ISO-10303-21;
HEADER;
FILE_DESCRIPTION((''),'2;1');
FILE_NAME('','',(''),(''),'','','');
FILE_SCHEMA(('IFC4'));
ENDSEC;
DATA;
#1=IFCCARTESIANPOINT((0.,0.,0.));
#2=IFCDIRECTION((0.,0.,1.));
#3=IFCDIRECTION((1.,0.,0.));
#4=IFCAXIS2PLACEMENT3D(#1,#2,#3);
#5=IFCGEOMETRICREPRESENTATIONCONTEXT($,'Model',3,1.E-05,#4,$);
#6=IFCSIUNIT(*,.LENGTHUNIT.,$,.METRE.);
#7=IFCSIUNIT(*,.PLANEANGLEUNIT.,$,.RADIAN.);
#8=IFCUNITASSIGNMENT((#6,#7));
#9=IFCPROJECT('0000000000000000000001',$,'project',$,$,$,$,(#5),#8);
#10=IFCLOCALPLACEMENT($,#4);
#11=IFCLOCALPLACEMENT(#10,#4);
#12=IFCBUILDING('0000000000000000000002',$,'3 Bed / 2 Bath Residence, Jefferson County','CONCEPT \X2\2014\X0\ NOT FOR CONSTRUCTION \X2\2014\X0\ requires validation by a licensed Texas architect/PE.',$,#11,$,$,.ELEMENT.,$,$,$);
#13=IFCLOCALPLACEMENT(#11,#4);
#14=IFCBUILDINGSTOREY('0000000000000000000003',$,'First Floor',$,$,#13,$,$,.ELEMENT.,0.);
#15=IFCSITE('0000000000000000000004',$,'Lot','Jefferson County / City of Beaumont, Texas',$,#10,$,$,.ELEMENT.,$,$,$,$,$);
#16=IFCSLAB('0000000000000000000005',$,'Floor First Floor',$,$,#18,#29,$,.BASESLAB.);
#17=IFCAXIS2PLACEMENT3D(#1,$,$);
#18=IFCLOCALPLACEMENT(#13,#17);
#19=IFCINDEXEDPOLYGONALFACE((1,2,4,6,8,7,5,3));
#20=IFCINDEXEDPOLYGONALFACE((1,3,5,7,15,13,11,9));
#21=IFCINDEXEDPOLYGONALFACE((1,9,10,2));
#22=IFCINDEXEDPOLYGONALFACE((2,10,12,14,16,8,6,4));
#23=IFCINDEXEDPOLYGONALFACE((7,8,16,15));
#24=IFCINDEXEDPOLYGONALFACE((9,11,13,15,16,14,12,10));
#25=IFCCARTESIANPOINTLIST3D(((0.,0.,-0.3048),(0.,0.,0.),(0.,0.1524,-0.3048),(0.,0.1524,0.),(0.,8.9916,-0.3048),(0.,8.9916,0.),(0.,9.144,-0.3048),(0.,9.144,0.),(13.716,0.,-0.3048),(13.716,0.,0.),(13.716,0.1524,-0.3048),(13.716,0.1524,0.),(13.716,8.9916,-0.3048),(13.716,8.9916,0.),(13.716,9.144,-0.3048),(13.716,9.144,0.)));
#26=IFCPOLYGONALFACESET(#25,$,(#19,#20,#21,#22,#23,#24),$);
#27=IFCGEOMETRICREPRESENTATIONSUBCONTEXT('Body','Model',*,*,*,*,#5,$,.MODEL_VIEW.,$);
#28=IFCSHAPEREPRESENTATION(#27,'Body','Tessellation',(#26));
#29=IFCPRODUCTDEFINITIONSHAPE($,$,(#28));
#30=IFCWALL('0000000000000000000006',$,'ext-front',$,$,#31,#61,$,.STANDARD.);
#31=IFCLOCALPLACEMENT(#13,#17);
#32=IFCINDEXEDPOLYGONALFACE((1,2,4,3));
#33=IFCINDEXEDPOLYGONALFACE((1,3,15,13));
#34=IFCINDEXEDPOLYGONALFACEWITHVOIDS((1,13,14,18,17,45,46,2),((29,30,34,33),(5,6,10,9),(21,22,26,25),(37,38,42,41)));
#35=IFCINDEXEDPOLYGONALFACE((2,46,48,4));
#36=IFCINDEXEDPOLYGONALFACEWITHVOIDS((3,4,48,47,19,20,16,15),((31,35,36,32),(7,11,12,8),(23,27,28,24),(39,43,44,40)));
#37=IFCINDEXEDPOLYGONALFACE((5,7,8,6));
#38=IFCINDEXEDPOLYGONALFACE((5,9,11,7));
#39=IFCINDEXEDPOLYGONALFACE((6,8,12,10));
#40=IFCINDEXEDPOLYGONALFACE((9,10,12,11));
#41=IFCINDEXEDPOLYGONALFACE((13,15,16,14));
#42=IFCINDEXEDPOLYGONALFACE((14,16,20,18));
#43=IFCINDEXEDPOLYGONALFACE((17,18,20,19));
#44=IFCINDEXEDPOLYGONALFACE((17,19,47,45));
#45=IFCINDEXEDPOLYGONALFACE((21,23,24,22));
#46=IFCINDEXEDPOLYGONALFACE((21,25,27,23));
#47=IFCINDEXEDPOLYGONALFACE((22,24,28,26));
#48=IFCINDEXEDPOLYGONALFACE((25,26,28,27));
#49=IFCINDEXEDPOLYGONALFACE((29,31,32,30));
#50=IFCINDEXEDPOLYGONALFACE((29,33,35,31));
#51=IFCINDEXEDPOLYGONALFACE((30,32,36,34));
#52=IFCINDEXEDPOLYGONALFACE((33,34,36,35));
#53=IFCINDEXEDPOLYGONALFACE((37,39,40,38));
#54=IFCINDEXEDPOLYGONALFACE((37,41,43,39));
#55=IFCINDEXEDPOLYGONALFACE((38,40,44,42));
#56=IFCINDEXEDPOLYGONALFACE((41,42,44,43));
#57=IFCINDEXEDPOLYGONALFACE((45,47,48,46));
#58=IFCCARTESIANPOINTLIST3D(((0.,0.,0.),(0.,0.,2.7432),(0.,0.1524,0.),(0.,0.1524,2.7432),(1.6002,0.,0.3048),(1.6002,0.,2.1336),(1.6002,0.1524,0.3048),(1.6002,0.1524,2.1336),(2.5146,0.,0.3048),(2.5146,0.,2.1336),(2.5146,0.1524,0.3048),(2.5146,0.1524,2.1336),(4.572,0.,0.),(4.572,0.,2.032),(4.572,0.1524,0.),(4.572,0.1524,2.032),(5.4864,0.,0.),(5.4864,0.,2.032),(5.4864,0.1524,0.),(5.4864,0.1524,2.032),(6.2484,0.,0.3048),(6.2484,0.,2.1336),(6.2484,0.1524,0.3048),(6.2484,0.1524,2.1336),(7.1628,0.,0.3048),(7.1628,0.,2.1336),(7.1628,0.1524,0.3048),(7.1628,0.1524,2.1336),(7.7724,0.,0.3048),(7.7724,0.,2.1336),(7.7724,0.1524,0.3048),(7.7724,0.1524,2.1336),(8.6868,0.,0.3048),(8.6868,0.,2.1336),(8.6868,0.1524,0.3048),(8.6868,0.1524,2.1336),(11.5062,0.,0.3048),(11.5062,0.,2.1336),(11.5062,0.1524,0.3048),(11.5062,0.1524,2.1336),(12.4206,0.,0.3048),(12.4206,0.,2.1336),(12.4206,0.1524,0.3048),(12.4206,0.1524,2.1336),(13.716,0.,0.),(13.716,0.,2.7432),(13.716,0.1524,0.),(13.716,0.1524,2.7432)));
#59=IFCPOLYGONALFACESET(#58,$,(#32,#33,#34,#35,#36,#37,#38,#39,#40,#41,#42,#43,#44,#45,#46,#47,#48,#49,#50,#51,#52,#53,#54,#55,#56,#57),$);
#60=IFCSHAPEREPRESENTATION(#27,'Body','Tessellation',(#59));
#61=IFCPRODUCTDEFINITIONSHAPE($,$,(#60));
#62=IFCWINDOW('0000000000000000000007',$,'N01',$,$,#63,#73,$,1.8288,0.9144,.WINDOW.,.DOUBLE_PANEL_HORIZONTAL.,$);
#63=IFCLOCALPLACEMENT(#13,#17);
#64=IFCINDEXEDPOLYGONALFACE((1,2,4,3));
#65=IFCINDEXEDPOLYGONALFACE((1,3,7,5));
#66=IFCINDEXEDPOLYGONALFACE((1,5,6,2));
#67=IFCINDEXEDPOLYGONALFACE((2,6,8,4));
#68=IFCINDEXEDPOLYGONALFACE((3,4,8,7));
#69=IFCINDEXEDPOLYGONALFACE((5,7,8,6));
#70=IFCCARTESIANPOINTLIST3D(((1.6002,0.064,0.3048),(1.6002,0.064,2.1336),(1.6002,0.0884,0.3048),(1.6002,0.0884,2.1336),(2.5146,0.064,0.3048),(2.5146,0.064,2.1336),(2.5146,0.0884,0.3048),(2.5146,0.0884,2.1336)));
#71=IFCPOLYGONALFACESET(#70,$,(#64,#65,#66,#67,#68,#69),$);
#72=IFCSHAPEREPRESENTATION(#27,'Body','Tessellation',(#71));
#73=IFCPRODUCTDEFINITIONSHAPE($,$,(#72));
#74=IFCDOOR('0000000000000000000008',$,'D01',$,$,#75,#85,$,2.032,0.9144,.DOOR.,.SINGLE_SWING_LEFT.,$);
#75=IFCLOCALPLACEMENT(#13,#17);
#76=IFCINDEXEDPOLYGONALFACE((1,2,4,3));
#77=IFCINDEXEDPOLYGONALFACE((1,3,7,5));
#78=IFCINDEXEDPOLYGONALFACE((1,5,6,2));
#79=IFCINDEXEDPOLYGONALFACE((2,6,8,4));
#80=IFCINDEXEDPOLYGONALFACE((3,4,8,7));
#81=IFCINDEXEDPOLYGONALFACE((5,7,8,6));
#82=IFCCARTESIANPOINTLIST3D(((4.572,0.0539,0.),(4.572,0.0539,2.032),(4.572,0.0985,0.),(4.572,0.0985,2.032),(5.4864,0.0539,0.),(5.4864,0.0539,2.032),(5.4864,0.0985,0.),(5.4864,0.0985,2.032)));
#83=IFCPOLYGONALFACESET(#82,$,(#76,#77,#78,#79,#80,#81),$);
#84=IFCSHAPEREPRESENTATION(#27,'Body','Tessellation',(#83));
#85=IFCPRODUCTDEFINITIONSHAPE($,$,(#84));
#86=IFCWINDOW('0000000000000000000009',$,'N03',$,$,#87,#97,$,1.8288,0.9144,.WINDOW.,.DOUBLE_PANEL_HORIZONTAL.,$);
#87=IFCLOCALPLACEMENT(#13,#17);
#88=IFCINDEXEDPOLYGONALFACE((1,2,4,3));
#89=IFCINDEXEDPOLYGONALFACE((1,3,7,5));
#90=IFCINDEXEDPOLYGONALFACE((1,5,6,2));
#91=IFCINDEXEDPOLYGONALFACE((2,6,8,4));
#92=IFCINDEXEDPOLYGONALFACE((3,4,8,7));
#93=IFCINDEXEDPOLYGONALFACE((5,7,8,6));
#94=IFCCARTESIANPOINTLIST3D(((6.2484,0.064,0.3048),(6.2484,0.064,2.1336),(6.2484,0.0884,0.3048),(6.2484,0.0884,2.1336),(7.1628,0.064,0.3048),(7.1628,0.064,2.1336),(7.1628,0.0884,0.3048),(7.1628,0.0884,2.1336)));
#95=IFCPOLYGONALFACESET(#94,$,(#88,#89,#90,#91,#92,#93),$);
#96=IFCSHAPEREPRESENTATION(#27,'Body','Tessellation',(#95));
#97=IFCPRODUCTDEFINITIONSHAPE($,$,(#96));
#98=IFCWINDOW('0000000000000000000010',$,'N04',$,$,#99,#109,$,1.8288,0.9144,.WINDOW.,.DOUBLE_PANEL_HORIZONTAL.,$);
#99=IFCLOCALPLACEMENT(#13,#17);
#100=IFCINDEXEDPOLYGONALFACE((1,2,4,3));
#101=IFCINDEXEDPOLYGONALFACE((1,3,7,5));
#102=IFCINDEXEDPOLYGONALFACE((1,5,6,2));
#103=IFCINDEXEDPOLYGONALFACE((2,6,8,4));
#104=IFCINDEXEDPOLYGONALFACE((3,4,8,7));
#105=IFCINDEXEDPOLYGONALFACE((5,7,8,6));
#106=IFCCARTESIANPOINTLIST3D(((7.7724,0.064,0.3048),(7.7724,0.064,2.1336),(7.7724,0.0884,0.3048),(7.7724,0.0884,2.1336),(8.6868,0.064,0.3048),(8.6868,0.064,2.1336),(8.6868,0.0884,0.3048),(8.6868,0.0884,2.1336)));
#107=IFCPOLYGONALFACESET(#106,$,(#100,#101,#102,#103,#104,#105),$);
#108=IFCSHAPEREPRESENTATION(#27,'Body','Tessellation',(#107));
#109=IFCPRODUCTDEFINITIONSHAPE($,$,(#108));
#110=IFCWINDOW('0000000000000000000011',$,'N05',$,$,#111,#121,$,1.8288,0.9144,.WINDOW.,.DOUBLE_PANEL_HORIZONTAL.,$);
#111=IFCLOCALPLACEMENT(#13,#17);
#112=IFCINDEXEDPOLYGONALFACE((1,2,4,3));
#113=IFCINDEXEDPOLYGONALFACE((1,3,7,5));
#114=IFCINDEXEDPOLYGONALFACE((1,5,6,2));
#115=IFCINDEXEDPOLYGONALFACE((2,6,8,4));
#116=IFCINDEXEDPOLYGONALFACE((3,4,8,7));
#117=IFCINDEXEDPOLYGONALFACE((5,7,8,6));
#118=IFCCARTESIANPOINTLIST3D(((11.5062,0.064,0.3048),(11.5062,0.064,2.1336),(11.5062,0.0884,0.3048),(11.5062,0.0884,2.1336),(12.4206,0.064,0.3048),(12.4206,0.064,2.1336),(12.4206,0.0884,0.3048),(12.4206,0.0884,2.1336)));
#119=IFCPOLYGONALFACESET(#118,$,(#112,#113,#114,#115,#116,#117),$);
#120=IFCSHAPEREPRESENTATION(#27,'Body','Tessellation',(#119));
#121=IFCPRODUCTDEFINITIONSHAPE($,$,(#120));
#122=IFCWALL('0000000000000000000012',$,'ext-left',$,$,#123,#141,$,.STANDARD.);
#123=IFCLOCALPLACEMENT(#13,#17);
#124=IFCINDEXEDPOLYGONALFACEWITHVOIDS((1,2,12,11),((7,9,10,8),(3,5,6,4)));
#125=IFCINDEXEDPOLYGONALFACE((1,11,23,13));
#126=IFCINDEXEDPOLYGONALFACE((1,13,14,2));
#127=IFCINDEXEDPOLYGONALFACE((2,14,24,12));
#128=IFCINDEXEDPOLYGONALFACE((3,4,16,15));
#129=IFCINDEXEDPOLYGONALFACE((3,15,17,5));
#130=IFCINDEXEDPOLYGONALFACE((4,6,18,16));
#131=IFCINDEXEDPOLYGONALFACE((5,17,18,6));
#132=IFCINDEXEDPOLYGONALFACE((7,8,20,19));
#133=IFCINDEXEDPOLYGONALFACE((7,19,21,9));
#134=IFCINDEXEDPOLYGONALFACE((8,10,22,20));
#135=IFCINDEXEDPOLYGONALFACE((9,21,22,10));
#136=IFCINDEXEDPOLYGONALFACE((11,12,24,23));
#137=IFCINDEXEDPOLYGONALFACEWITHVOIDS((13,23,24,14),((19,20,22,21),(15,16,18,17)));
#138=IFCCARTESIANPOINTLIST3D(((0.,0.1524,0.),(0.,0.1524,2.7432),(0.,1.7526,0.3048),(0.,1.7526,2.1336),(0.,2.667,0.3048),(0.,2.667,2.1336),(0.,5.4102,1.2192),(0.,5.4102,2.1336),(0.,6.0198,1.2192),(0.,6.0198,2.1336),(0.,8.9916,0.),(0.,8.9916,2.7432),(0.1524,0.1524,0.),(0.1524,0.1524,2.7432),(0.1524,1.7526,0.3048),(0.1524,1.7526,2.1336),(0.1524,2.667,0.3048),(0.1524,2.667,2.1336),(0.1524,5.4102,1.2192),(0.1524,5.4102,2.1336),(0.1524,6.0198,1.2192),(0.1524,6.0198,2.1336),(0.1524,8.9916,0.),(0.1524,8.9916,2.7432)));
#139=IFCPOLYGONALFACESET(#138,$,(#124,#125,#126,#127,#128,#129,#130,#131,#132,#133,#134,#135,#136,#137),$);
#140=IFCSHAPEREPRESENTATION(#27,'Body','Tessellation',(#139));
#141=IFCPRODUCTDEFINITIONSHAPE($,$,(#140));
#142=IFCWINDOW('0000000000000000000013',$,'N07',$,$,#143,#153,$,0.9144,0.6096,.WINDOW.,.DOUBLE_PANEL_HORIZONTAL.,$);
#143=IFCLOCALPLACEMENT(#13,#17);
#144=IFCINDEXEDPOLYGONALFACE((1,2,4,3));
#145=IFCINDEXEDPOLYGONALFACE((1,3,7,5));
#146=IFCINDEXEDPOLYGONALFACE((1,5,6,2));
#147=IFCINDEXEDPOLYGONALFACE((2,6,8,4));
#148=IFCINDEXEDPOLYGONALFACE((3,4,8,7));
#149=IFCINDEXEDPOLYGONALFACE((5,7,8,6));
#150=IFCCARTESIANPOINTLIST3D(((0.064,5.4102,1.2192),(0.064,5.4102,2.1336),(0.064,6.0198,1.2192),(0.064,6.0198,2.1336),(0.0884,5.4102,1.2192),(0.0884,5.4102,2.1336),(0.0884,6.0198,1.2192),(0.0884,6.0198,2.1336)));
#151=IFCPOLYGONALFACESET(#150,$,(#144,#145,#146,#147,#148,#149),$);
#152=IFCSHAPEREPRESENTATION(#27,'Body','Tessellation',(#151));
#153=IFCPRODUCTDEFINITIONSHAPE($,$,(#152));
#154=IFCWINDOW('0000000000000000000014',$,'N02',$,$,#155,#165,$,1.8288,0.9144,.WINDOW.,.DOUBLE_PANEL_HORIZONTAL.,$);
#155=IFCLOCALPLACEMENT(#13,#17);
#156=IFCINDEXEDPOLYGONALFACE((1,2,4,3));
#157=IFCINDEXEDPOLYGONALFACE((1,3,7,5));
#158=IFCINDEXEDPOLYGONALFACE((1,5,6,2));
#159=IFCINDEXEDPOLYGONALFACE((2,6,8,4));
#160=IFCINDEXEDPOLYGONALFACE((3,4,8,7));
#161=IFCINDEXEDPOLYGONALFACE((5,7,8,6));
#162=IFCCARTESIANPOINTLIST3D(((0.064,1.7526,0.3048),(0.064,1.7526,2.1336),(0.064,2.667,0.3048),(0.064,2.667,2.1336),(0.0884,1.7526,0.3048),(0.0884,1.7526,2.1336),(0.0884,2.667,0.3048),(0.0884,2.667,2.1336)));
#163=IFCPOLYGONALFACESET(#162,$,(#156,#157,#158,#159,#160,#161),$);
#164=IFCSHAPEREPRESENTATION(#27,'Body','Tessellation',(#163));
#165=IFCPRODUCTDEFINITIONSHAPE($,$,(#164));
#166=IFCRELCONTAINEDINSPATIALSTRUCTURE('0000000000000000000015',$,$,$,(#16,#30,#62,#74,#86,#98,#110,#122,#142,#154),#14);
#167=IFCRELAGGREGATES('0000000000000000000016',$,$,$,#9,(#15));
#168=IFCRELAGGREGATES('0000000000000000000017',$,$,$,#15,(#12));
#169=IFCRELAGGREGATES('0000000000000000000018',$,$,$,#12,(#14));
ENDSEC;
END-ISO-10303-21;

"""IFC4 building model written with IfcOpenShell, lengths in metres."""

from ifc_helpers import new_model, si_unit, frame, frame_2d, origin_with_axes, place, context, subcontext, project, spatial, polyline, rectangle, outline, extrude, element, fill, save


model = new_model("IFC4")

# Units and contexts
model_context = context("Model", 3, precision=1e-05, world=origin_with_axes())
body_context = subcontext(model_context, "Body", "Model", "MODEL_VIEW")
ifc_project = project(units=[si_unit("LENGTHUNIT", "METRE"), si_unit("PLANEANGLEUNIT", "RADIAN")], contexts=[model_context])

# Site, building, storey
site_placement = place(None, origin_with_axes())
site = spatial("IfcSite", under=ifc_project, at=site_placement, Name="Lot", Description="Jefferson County / City of Beaumont, Texas", CompositionType="ELEMENT")
building_placement = place(site_placement, origin_with_axes())
building = spatial("IfcBuilding", under=site, at=building_placement, Name="3 Bed / 2 Bath Residence, Jefferson County", Description="CONCEPT — NOT FOR CONSTRUCTION — requires validation by a licensed Texas architect/PE.", CompositionType="ELEMENT")
storey_placement = place(building_placement, origin_with_axes())
storey = spatial("IfcBuildingStorey", under=building, at=storey_placement, Name="First Floor", CompositionType="ELEMENT", Elevation=0.0)

# Slab
slab_placement = place(storey_placement, frame((0.0, 0.0, -0.3048), z_axis=(0.0, 0.0, 1.0), x_axis=(1.0, 0.0, 0.0)))
element("IfcSlab", 1, at=slab_placement, inside=storey, Name="Floor First Floor", PredefinedType="BASESLAB", context=body_context, shape_type="SweptSolid", body=[
    extrude(outline(polyline([(13.716, 8.9916), (13.716, 0.1524), (13.716, 0.0), (0.0, 0.0), (0.0, 0.1524), (0.0, 8.9916), (0.0, 9.144), (13.716, 9.144), (13.716, 8.9916)])), origin_with_axes(), (0.0, 0.0, 1.0), 0.3048),
])

# Wall, openings, windows, door
wall_1_placement = place(storey_placement, frame((0.0, 0.0762, 0.0), z_axis=(0.0, 0.0, 1.0), x_axis=(1.0, 0.0, 0.0)))
wall_1 = element("IfcWall", 2, at=wall_1_placement, inside=storey, Name="ext-front", PredefinedType="STANDARD", context=body_context, shape_type="SweptSolid", body=[
    extrude(rectangle(XDim=13.716, YDim=0.1524, at=frame_2d((6.858, 0.0), x_axis=(1.0, 0.0))), origin_with_axes(), (0.0, 0.0, 1.0), 2.7432),
])
opening_1_placement = place(wall_1_placement, frame((1.6002, 0.0, 0.3048), z_axis=(0.0, 0.0, 1.0), x_axis=(1.0, 0.0, 0.0)))
opening_1 = element("IfcOpeningElement", 3, at=opening_1_placement, cuts=wall_1, PredefinedType="OPENING", context=body_context, shape_type="SweptSolid", body=[
    extrude(rectangle(XDim=0.9144, YDim=0.1829, at=frame_2d((0.4572, 0.0), x_axis=(1.0, 0.0))), origin_with_axes(), (0.0, 0.0, 1.0), 1.8288),
])
opening_2_placement = place(wall_1_placement, frame((4.572, 0.0, 0.0), z_axis=(0.0, 0.0, 1.0), x_axis=(1.0, 0.0, 0.0)))
opening_2 = element("IfcOpeningElement", 4, at=opening_2_placement, cuts=wall_1, PredefinedType="OPENING", context=body_context, shape_type="SweptSolid", body=[
    extrude(rectangle(XDim=0.9144, YDim=0.1829, at=frame_2d((0.4572, 0.0), x_axis=(1.0, 0.0))), origin_with_axes(), (0.0, 0.0, 1.0), 2.032),
])
opening_3_placement = place(wall_1_placement, frame((6.2484, 0.0, 0.3048), z_axis=(0.0, 0.0, 1.0), x_axis=(1.0, 0.0, 0.0)))
opening_3 = element("IfcOpeningElement", 5, at=opening_3_placement, cuts=wall_1, PredefinedType="OPENING", context=body_context, shape_type="SweptSolid", body=[
    extrude(rectangle(XDim=0.9144, YDim=0.1829, at=frame_2d((0.4572, 0.0), x_axis=(1.0, 0.0))), origin_with_axes(), (0.0, 0.0, 1.0), 1.8288),
])
opening_4_placement = place(wall_1_placement, frame((7.7724, 0.0, 0.3048), z_axis=(0.0, 0.0, 1.0), x_axis=(1.0, 0.0, 0.0)))
opening_4 = element("IfcOpeningElement", 6, at=opening_4_placement, cuts=wall_1, PredefinedType="OPENING", context=body_context, shape_type="SweptSolid", body=[
    extrude(rectangle(XDim=0.9144, YDim=0.1829, at=frame_2d((0.4572, 0.0), x_axis=(1.0, 0.0))), origin_with_axes(), (0.0, 0.0, 1.0), 1.8288),
])
opening_5_placement = place(wall_1_placement, frame((11.5062, 0.0, 0.3048), z_axis=(0.0, 0.0, 1.0), x_axis=(1.0, 0.0, 0.0)))
opening_5 = element("IfcOpeningElement", 7, at=opening_5_placement, cuts=wall_1, PredefinedType="OPENING", context=body_context, shape_type="SweptSolid", body=[
    extrude(rectangle(XDim=0.9144, YDim=0.1829, at=frame_2d((0.4572, 0.0), x_axis=(1.0, 0.0))), origin_with_axes(), (0.0, 0.0, 1.0), 1.8288),
])
window_1_placement = place(opening_1_placement, origin_with_axes())
window_1 = element("IfcWindow", 8, at=window_1_placement, inside=storey, Name="N01", OverallHeight=1.8288, OverallWidth=0.9144, PartitioningType="DOUBLE_PANEL_HORIZONTAL", PredefinedType="WINDOW", context=body_context, shape_type="SweptSolid", body=[
    extrude(rectangle(XDim=0.9144, YDim=0.0244, at=frame_2d((0.4572, 0.0), x_axis=(1.0, 0.0))), origin_with_axes(), (0.0, 0.0, 1.0), 1.8288),
])
fill(opening_1, window_1)
door_1_placement = place(opening_2_placement, origin_with_axes())
door_1 = element("IfcDoor", 9, at=door_1_placement, inside=storey, Name="D01", OperationType="SINGLE_SWING_LEFT", OverallHeight=2.032, OverallWidth=0.9144, PredefinedType="DOOR", context=body_context, shape_type="SweptSolid", body=[
    extrude(rectangle(XDim=0.9144, YDim=0.0445, at=frame_2d((0.4572, 0.0), x_axis=(1.0, 0.0))), origin_with_axes(), (0.0, 0.0, 1.0), 2.032),
])
fill(opening_2, door_1)
window_2_placement = place(opening_3_placement, origin_with_axes())
window_2 = element("IfcWindow", 10, at=window_2_placement, inside=storey, Name="N03", OverallHeight=1.8288, OverallWidth=0.9144, PartitioningType="DOUBLE_PANEL_HORIZONTAL", PredefinedType="WINDOW", context=body_context, shape_type="SweptSolid", body=[
    extrude(rectangle(XDim=0.9144, YDim=0.0244, at=frame_2d((0.4572, 0.0), x_axis=(1.0, 0.0))), origin_with_axes(), (0.0, 0.0, 1.0), 1.8288),
])
fill(opening_3, window_2)
window_3_placement = place(opening_4_placement, origin_with_axes())
window_3 = element("IfcWindow", 11, at=window_3_placement, inside=storey, Name="N04", OverallHeight=1.8288, OverallWidth=0.9144, PartitioningType="DOUBLE_PANEL_HORIZONTAL", PredefinedType="WINDOW", context=body_context, shape_type="SweptSolid", body=[
    extrude(rectangle(XDim=0.9144, YDim=0.0244, at=frame_2d((0.4572, 0.0), x_axis=(1.0, 0.0))), origin_with_axes(), (0.0, 0.0, 1.0), 1.8288),
])
fill(opening_4, window_3)
window_4_placement = place(opening_5_placement, origin_with_axes())
window_4 = element("IfcWindow", 12, at=window_4_placement, inside=storey, Name="N05", OverallHeight=1.8288, OverallWidth=0.9144, PartitioningType="DOUBLE_PANEL_HORIZONTAL", PredefinedType="WINDOW", context=body_context, shape_type="SweptSolid", body=[
    extrude(rectangle(XDim=0.9144, YDim=0.0244, at=frame_2d((0.4572, 0.0), x_axis=(1.0, 0.0))), origin_with_axes(), (0.0, 0.0, 1.0), 1.8288),
])
fill(opening_5, window_4)

# Wall, openings, windows
wall_2_placement = place(storey_placement, frame((0.0762, 8.9916, 0.0), z_axis=(0.0, 0.0, 1.0), x_axis=(0.0, -1.0, 0.0)))
wall_2 = element("IfcWall", 13, at=wall_2_placement, inside=storey, Name="ext-left", PredefinedType="STANDARD", context=body_context, shape_type="SweptSolid", body=[
    extrude(rectangle(XDim=8.8392, YDim=0.1524, at=frame_2d((4.4196, 0.0), x_axis=(1.0, 0.0))), origin_with_axes(), (0.0, 0.0, 1.0), 2.7432),
])
opening_6_placement = place(wall_2_placement, frame((2.9718, 0.0, 1.2192), z_axis=(0.0, 0.0, 1.0), x_axis=(1.0, 0.0, 0.0)))
opening_6 = element("IfcOpeningElement", 14, at=opening_6_placement, cuts=wall_2, PredefinedType="OPENING", context=body_context, shape_type="SweptSolid", body=[
    extrude(rectangle(XDim=0.6096, YDim=0.1829, at=frame_2d((0.3048, 0.0), x_axis=(1.0, 0.0))), origin_with_axes(), (0.0, 0.0, 1.0), 0.9144),
])
opening_7_placement = place(wall_2_placement, frame((6.3246, 0.0, 0.3048), z_axis=(0.0, 0.0, 1.0), x_axis=(1.0, 0.0, 0.0)))
opening_7 = element("IfcOpeningElement", 15, at=opening_7_placement, cuts=wall_2, PredefinedType="OPENING", context=body_context, shape_type="SweptSolid", body=[
    extrude(rectangle(XDim=0.9144, YDim=0.1829, at=frame_2d((0.4572, 0.0), x_axis=(1.0, 0.0))), origin_with_axes(), (0.0, 0.0, 1.0), 1.8288),
])
window_5_placement = place(opening_6_placement, origin_with_axes())
window_5 = element("IfcWindow", 16, at=window_5_placement, inside=storey, Name="N07", OverallHeight=0.9144, OverallWidth=0.6096, PartitioningType="DOUBLE_PANEL_HORIZONTAL", PredefinedType="WINDOW", context=body_context, shape_type="SweptSolid", body=[
    extrude(rectangle(XDim=0.6096, YDim=0.0244, at=frame_2d((0.3048, 0.0), x_axis=(1.0, 0.0))), origin_with_axes(), (0.0, 0.0, 1.0), 0.9144),
])
fill(opening_6, window_5)
window_6_placement = place(opening_7_placement, origin_with_axes())
window_6 = element("IfcWindow", 17, at=window_6_placement, inside=storey, Name="N02", OverallHeight=1.8288, OverallWidth=0.9144, PartitioningType="DOUBLE_PANEL_HORIZONTAL", PredefinedType="WINDOW", context=body_context, shape_type="SweptSolid", body=[
    extrude(rectangle(XDim=0.9144, YDim=0.0244, at=frame_2d((0.4572, 0.0), x_axis=(1.0, 0.0))), origin_with_axes(), (0.0, 0.0, 1.0), 1.8288),
])
fill(opening_7, window_6)

save(model, "model.ifc")
